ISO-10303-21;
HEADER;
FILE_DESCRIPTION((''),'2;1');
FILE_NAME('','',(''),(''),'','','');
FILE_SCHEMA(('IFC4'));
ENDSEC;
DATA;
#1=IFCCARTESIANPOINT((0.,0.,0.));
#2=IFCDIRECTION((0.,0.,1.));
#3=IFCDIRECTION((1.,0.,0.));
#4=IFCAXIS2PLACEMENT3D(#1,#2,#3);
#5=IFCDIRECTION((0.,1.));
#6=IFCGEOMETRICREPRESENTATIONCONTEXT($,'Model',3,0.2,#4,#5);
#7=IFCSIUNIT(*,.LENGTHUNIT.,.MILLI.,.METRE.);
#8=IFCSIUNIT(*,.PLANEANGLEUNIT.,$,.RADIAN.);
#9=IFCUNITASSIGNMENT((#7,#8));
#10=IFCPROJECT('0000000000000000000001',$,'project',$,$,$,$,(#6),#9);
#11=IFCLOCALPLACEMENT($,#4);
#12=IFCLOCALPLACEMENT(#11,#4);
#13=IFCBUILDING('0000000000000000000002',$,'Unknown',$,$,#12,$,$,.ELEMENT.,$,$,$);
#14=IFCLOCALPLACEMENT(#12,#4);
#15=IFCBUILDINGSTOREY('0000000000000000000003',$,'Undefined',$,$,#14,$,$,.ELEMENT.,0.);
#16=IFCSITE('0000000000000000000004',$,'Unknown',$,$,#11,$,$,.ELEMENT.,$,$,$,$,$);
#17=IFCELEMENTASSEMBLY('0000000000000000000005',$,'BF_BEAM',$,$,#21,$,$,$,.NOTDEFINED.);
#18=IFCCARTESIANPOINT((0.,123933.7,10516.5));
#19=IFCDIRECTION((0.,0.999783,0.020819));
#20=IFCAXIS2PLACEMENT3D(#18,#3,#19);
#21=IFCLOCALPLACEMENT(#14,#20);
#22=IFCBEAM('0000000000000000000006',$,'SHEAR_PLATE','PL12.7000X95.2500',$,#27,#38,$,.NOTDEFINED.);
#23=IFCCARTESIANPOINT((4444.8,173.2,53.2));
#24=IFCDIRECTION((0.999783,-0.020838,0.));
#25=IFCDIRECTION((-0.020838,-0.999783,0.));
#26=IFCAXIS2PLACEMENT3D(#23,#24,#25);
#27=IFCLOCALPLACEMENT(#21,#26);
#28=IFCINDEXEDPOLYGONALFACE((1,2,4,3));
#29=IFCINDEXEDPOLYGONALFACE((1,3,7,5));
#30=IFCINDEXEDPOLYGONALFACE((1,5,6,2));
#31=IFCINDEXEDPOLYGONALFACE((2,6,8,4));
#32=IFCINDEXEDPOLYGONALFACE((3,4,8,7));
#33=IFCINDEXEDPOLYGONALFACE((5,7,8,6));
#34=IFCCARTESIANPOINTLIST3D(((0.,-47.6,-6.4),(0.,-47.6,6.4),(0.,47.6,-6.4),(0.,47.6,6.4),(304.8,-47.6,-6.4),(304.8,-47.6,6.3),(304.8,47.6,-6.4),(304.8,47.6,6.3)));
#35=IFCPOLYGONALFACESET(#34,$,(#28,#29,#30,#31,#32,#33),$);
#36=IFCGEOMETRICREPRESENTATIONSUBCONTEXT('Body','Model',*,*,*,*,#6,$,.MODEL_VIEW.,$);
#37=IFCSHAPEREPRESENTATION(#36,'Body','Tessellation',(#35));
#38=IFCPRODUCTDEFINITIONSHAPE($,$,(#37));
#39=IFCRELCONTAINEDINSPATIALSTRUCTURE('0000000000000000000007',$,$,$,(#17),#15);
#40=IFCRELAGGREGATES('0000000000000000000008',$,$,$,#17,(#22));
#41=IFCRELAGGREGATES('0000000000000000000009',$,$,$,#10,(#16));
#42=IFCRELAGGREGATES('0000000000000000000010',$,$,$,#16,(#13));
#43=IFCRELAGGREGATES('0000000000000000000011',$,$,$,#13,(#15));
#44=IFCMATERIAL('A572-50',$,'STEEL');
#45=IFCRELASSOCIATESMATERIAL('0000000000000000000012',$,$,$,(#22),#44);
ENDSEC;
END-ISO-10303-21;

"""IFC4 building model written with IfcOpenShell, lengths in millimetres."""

from ifc_helpers import new_model, si_unit, direction, frame, origin_with_axes, place, context, subcontext, project, spatial, line, indexed_curve, outline, extrude, material, element, aggregate, save


model = new_model("IFC4")

# Units and contexts
model_context = context("Model", 3, precision=0.2, world=origin_with_axes(), true_north=direction((0.0, 1.0)))
body_context = subcontext(model_context, "Body", "Model", "MODEL_VIEW")
ifc_project = project(units=[si_unit("LENGTHUNIT", "METRE", prefix="MILLI"), si_unit("PLANEANGLEUNIT", "RADIAN")], contexts=[model_context])

# Site, building, storey
site_placement = place(None, origin_with_axes())
site = spatial("IfcSite", under=ifc_project, at=site_placement, Name="Unknown", CompositionType="ELEMENT")
building_placement = place(site_placement, origin_with_axes())
building = spatial("IfcBuilding", under=site, at=building_placement, Name="Unknown", CompositionType="ELEMENT")
storey_placement = place(building_placement, origin_with_axes())
storey = spatial("IfcBuildingStorey", under=building, at=storey_placement, Name="Undefined", CompositionType="ELEMENT", Elevation=0.0)

# Shared definitions
ifc_material_1 = material(Name="A572-50", Category="STEEL")

# Element assembly, beam
assembly_1_placement = place(storey_placement, frame((0.0, 123933.7, 10516.5), z_axis=(1.0, 0.0, 0.0), x_axis=(0.0, 0.999783, 0.020819)))
assembly_1 = element("IfcElementAssembly", 1, at=assembly_1_placement, inside=storey, Name="BF_BEAM", PredefinedType="NOTDEFINED")
beam_1_placement = place(assembly_1_placement, frame((4444.8, 173.2, 53.2), z_axis=(0.999783, -0.020838, 0.0), x_axis=(-0.020838, -0.999783, 0.0)))
beam_1 = element("IfcBeam", 2, at=beam_1_placement, material=ifc_material_1, Name="SHEAR_PLATE", Description="PL12.7000X95.2500", PredefinedType="NOTDEFINED", context=body_context, shape_type="SolidModel", body=[
    extrude(outline(indexed_curve([(-6.3, -47.6), (6.3, -47.6), (6.3, 47.6), (-6.3, 47.6)], segments=[line(1, 2, 3, 4, 1)])), frame((0.0, 0.0, 0.0), z_axis=(-1.0, 0.0, 0.0), x_axis=(0.0, 0.0, 1.0)), (0.0, 0.0, -1.0), 304.8),
])
aggregate(assembly_1, [beam_1])

save(model, "model.ifc")
